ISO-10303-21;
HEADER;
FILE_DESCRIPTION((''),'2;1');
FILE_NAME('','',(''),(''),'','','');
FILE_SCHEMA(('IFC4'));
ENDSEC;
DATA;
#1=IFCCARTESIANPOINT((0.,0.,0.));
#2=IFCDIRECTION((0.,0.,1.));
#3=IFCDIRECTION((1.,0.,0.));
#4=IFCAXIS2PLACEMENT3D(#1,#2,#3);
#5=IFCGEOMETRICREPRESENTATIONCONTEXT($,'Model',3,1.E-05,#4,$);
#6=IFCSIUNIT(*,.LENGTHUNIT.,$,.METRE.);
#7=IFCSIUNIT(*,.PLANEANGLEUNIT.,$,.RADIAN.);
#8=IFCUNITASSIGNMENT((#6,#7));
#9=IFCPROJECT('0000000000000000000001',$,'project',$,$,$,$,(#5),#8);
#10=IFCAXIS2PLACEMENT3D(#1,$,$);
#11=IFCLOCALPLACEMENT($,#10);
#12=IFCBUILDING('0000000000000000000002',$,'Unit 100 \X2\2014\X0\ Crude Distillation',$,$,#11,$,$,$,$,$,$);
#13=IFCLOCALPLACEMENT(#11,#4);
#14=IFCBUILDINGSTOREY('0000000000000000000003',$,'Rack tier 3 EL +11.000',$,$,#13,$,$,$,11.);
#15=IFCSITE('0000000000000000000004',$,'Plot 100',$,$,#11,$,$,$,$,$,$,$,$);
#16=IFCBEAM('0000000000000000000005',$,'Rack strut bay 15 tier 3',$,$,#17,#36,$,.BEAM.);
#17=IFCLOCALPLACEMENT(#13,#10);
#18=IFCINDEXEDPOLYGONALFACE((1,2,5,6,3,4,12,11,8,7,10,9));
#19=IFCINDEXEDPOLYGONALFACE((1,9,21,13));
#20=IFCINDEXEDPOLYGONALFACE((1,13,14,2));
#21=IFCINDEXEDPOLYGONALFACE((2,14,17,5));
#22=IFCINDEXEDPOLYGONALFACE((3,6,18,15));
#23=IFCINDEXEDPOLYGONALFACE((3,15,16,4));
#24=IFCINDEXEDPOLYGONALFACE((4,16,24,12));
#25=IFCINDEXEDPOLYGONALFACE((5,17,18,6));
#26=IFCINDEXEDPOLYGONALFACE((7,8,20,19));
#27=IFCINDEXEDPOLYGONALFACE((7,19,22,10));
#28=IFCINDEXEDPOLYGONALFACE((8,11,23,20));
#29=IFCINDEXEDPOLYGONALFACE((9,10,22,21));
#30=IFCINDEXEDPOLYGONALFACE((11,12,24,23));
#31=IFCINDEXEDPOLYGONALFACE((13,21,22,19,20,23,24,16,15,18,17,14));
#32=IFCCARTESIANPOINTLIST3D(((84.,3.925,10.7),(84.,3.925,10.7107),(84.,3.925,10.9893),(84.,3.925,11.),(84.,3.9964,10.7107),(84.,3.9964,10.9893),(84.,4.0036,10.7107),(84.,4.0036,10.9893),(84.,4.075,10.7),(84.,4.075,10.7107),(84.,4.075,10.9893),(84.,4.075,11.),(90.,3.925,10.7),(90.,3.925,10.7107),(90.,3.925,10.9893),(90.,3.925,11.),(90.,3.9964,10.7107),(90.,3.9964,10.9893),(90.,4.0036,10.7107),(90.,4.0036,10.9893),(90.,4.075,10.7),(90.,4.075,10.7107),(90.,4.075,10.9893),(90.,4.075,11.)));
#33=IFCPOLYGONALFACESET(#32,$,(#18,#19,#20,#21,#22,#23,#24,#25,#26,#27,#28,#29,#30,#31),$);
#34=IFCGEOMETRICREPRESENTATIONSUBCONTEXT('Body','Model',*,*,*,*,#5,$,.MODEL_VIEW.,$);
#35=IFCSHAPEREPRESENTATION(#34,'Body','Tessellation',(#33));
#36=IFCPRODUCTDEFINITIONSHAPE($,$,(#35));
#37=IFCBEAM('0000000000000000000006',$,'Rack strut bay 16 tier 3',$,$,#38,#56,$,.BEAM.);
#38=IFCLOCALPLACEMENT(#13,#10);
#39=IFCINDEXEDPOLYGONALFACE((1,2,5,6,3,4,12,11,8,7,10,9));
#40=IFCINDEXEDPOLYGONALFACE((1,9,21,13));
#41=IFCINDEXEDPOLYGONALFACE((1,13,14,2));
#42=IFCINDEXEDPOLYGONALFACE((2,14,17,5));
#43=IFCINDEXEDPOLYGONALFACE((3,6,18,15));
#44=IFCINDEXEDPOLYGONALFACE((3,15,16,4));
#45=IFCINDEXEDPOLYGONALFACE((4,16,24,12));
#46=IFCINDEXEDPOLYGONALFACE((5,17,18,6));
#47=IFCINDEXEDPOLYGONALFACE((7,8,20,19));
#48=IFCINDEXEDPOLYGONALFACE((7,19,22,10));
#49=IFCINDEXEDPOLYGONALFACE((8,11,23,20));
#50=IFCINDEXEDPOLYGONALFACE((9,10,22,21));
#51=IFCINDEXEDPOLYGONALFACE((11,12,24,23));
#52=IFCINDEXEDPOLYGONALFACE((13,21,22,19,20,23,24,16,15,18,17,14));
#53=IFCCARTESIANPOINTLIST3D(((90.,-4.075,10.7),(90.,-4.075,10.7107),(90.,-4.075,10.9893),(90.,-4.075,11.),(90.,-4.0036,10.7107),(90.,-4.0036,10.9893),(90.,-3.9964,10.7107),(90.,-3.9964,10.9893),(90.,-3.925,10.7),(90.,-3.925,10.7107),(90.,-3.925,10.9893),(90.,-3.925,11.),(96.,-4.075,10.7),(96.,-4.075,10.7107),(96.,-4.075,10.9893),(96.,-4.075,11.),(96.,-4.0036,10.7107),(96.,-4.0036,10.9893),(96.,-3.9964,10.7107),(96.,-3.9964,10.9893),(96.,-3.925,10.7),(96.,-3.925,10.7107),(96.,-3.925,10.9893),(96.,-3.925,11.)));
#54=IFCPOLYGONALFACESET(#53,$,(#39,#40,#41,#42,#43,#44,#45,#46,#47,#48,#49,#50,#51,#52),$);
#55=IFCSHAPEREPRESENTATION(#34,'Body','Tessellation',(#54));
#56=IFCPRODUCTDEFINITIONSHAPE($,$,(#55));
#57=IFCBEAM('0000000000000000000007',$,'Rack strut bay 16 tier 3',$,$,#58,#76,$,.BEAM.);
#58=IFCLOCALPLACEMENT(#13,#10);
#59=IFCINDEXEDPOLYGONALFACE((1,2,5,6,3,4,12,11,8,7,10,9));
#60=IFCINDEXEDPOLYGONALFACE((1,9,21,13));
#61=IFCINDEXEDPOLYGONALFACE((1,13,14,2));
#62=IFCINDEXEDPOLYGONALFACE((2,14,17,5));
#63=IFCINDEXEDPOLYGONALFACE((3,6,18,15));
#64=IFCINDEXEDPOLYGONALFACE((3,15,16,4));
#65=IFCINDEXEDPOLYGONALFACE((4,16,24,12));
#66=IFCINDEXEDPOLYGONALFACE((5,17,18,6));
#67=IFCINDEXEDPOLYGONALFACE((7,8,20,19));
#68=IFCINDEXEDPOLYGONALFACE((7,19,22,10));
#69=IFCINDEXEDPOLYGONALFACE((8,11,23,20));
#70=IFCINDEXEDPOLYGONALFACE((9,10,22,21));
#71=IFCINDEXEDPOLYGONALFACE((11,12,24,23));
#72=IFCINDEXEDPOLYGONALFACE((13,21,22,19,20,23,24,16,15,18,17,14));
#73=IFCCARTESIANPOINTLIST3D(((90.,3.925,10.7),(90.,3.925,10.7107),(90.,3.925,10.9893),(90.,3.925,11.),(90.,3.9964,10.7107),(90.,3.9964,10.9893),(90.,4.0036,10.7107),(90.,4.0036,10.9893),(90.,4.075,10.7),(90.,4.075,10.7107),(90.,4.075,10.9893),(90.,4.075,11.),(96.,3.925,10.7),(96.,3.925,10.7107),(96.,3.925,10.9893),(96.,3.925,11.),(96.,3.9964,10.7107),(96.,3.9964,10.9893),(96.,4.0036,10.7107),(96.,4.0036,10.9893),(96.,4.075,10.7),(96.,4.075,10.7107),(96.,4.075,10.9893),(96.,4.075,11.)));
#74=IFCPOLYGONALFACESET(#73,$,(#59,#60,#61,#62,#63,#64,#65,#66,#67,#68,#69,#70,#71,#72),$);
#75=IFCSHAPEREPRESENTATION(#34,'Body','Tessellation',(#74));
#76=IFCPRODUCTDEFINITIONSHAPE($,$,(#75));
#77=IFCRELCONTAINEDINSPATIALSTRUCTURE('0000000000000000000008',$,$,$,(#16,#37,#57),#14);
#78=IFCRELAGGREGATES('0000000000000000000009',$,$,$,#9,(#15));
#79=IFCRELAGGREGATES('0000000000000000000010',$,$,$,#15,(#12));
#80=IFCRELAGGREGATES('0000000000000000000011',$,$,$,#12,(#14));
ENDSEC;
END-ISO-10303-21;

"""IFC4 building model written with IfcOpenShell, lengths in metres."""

from ifc_helpers import new_model, si_unit, frame, origin, origin_with_axes, origin_2d, place, context, subcontext, project, spatial, i_section, extrude, element, save


model = new_model("IFC4")

# Units and contexts
model_context = context("Model", 3, precision=1e-05, world=origin_with_axes())
body_context = subcontext(model_context, "Body", "Model", "MODEL_VIEW")
ifc_project = project(units=[si_unit("LENGTHUNIT", "METRE"), si_unit("PLANEANGLEUNIT", "RADIAN")], contexts=[model_context])

# Site, building, storey
placement = place(None, origin())
site = spatial("IfcSite", under=ifc_project, at=placement, Name="Plot 100")
building = spatial("IfcBuilding", under=site, at=placement, Name="Unit 100 — Crude Distillation")
storey_placement = place(placement, origin_with_axes())
storey = spatial("IfcBuildingStorey", under=building, at=storey_placement, Name="Rack tier 3 EL +11.000", Elevation=11.0)

# Beams
beam_1_placement = place(storey_placement, origin_with_axes())
element("IfcBeam", 1, at=beam_1_placement, inside=storey, Name="Rack strut bay 15 tier 3", PredefinedType="BEAM", context=body_context, shape_type="SweptSolid", body=[
    extrude(i_section(OverallWidth=0.15, OverallDepth=0.3, WebThickness=0.0071, FlangeThickness=0.0107, at=origin_2d()), frame((84.0, 4.0, 10.85), z_axis=(1.0, 0.0, 0.0), x_axis=(0.0, 1.0, 0.0)), (0.0, 0.0, 1.0), 6.0),
])
beam_2_placement = place(storey_placement, origin_with_axes())
element("IfcBeam", 2, at=beam_2_placement, inside=storey, Name="Rack strut bay 16 tier 3", PredefinedType="BEAM", context=body_context, shape_type="SweptSolid", body=[
    extrude(i_section(OverallWidth=0.15, OverallDepth=0.3, WebThickness=0.0071, FlangeThickness=0.0107, at=origin_2d()), frame((90.0, -4.0, 10.85), z_axis=(1.0, 0.0, 0.0), x_axis=(0.0, 1.0, 0.0)), (0.0, 0.0, 1.0), 6.0),
])
beam_3_placement = place(storey_placement, origin_with_axes())
element("IfcBeam", 3, at=beam_3_placement, inside=storey, Name="Rack strut bay 16 tier 3", PredefinedType="BEAM", context=body_context, shape_type="SweptSolid", body=[
    extrude(i_section(OverallWidth=0.15, OverallDepth=0.3, WebThickness=0.0071, FlangeThickness=0.0107, at=origin_2d()), frame((90.0, 4.0, 10.85), z_axis=(1.0, 0.0, 0.0), x_axis=(0.0, 1.0, 0.0)), (0.0, 0.0, 1.0), 6.0),
])

save(model, "model.ifc")
